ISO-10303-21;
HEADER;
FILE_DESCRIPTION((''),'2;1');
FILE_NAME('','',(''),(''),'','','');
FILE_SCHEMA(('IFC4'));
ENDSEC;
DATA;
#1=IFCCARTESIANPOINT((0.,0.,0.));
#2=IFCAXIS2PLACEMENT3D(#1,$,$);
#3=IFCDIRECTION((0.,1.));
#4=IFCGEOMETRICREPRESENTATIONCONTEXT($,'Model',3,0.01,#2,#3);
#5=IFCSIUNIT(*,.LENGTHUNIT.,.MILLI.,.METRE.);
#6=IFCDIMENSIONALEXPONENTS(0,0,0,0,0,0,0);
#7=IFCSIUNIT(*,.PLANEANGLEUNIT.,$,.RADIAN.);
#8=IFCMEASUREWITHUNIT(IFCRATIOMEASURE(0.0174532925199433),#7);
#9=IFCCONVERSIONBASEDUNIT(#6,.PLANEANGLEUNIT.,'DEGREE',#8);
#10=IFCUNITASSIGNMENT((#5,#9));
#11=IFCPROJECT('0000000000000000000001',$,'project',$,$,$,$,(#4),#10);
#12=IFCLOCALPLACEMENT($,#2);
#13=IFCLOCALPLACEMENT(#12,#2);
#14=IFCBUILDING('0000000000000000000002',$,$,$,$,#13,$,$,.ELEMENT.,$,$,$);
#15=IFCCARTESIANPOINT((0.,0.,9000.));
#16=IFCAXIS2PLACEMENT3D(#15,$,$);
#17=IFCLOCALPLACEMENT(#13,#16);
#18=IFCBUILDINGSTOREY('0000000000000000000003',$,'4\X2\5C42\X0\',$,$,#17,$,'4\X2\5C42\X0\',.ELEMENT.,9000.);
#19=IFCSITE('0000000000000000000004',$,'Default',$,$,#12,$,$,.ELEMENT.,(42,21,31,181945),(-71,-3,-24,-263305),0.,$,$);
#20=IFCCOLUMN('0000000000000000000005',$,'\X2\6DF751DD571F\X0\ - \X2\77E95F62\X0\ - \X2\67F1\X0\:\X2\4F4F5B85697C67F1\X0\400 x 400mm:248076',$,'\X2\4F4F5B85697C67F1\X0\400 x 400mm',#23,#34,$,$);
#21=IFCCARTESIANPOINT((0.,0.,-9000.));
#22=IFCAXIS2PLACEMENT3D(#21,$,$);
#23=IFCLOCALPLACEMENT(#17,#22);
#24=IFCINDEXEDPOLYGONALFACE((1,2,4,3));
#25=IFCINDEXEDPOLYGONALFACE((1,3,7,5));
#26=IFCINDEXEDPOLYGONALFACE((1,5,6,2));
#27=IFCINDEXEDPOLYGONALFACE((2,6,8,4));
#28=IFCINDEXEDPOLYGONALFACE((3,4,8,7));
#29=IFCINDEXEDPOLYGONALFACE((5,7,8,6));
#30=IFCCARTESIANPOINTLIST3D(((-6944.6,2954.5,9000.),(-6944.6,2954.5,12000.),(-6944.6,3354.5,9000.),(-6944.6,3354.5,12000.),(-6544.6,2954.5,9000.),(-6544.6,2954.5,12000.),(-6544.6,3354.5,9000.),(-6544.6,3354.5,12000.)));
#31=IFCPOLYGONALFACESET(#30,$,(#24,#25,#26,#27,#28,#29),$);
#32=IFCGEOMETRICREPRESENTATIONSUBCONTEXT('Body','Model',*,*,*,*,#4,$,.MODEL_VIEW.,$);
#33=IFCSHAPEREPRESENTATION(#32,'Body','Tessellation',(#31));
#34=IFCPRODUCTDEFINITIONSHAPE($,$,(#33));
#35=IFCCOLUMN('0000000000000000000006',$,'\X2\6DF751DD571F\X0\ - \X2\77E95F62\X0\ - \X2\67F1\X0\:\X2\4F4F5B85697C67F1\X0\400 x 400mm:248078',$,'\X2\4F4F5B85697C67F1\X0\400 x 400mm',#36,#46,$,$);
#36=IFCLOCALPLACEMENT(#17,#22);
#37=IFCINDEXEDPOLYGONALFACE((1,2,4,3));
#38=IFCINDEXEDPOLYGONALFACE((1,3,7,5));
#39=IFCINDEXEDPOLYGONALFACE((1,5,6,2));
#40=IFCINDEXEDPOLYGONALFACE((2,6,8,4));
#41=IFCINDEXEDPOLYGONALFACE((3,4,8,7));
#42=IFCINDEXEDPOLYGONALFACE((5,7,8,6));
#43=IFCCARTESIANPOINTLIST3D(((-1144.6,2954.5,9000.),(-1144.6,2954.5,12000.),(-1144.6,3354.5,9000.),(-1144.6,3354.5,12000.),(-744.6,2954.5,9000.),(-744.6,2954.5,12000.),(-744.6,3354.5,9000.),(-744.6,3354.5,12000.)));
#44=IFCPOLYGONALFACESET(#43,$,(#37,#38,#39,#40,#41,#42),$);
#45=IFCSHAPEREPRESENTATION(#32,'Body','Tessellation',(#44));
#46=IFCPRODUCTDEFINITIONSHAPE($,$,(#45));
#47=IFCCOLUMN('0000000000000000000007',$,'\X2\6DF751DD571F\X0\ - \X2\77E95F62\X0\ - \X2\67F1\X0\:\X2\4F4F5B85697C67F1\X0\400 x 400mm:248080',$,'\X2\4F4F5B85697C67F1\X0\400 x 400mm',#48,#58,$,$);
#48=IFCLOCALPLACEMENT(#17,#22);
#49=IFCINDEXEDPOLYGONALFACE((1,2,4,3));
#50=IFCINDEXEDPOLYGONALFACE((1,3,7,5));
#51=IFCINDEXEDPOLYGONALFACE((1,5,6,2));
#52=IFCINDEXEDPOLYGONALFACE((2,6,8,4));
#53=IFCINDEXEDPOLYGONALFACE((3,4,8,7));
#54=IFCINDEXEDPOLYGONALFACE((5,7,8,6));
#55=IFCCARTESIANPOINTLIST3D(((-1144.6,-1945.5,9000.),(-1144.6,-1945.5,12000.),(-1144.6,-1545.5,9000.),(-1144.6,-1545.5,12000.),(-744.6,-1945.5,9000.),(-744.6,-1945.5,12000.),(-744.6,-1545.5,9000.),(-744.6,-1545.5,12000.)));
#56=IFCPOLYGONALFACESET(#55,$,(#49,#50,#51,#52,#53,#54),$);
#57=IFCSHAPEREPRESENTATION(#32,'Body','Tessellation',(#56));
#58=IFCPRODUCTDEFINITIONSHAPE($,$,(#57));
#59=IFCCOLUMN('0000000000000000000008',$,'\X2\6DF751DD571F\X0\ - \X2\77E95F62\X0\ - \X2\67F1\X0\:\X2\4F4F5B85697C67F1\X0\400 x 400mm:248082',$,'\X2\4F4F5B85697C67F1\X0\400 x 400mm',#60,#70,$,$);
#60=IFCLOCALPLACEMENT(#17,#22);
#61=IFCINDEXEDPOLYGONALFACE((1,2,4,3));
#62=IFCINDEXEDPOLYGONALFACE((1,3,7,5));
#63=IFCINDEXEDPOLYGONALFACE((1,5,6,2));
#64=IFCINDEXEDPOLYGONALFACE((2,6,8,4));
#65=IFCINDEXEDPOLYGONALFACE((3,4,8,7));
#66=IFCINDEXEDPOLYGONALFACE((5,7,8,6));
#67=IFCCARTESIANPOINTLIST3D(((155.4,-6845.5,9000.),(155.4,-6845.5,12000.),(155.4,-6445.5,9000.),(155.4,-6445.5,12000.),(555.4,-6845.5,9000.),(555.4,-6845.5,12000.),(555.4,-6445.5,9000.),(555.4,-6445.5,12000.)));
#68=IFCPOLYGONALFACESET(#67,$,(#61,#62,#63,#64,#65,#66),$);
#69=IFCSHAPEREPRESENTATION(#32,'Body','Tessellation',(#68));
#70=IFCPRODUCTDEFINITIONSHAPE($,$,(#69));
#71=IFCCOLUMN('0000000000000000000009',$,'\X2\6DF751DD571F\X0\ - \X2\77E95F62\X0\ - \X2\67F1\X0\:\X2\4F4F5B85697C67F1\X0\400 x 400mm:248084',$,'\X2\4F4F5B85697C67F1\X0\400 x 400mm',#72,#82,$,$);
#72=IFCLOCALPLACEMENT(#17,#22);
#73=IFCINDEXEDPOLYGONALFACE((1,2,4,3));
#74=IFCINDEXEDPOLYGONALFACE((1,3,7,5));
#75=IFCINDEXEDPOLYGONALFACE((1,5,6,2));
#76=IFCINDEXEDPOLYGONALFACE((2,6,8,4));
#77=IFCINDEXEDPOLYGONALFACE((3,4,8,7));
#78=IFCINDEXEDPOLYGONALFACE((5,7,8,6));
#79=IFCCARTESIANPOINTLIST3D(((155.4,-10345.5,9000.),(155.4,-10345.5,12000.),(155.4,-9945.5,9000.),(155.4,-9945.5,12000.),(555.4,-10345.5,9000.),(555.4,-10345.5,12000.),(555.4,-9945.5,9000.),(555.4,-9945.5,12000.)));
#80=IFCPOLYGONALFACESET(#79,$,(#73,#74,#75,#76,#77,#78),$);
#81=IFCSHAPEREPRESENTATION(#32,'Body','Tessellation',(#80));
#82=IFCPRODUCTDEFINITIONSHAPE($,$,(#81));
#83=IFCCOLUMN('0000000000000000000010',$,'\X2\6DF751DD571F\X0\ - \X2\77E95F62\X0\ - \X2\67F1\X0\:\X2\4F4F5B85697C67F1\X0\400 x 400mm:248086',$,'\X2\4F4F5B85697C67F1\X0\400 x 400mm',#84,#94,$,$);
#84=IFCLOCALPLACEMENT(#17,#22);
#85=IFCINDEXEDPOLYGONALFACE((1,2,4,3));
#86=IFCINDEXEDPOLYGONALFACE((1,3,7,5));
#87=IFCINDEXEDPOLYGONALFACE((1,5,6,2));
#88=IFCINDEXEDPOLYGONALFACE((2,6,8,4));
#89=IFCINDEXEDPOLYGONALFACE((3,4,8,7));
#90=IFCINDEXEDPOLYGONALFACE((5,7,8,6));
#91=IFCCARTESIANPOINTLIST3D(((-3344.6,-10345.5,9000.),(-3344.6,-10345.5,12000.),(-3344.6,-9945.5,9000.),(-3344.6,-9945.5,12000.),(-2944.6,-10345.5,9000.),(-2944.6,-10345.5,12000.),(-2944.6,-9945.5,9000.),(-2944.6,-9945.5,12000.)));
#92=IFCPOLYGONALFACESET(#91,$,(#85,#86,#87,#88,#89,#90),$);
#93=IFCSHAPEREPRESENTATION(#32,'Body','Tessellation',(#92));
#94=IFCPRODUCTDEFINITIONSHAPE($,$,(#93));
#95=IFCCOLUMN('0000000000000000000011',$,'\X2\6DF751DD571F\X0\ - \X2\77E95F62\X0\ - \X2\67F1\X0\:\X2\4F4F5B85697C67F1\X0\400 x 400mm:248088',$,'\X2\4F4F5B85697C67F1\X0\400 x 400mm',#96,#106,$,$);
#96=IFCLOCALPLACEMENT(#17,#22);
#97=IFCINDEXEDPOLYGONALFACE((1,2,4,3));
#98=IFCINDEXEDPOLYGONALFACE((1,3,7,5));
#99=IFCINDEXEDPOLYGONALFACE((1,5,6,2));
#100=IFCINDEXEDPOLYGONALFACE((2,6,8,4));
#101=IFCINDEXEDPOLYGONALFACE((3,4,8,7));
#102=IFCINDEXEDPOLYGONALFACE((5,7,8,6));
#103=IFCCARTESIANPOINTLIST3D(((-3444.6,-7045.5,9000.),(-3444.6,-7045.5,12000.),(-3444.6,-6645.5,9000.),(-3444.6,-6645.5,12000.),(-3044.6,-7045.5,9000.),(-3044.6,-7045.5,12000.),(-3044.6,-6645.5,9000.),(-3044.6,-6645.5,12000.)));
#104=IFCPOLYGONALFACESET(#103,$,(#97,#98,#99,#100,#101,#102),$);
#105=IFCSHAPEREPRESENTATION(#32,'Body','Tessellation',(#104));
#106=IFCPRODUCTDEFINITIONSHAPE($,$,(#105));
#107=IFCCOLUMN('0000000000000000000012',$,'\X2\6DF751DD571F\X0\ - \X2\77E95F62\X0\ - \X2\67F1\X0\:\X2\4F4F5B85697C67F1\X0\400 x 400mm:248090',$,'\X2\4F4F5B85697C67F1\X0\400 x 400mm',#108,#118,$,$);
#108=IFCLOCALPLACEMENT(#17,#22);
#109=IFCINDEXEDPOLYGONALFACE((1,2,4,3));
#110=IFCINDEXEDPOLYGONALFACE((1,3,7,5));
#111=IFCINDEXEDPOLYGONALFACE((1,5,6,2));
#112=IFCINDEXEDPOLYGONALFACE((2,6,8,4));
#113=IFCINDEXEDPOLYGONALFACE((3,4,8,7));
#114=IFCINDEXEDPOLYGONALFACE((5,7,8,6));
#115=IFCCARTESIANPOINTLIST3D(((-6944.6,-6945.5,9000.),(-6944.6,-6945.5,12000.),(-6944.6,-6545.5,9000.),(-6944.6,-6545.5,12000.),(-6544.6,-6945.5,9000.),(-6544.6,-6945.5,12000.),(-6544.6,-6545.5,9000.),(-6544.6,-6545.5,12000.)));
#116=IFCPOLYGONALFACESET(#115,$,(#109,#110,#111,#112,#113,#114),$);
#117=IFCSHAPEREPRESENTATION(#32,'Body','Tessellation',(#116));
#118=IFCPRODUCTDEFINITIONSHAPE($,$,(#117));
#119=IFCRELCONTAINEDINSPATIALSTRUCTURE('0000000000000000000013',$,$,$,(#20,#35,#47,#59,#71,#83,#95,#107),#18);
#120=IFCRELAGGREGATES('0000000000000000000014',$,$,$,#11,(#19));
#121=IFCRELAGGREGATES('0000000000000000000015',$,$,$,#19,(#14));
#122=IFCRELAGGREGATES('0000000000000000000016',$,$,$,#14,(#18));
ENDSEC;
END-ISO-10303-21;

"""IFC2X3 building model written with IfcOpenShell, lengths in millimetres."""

from ifc_helpers import new_model, entity, si_unit, converted_unit, direction, frame, frame_2d, origin, origin_2d_with_axis, place, context, subcontext, project, spatial, rectangle, extrude, source, transform, mapped, element, save


model = new_model("IFC2X3")

# Units and contexts
model_context = context("Model", 3, precision=0.01, world=origin(), true_north=direction((0.0, 1.0)))
body_context = subcontext(model_context, "Body", "Model", "MODEL_VIEW")
ifc_project = project(units=[si_unit("LENGTHUNIT", "METRE", prefix="MILLI"), converted_unit("PLANEANGLEUNIT", "DEGREE", entity("IfcRatioMeasure", 0.0174532925199433), si_unit("PLANEANGLEUNIT", "RADIAN"), dimensions=[0, 0, 0, 0, 0, 0, 0])], contexts=[model_context])

# Site, building, storey
site_placement = place(None, origin())
site = spatial("IfcSite", under=ifc_project, at=site_placement, Name="Default", CompositionType="ELEMENT", RefLatitude=(42, 21, 31, 181945), RefLongitude=(-71, -3, -24, -263305), RefElevation=0.0)
building_placement = place(site_placement, origin())
building = spatial("IfcBuilding", under=site, at=building_placement, CompositionType="ELEMENT")
storey_placement = place(building_placement, frame((0.0, 0.0, 9000.0)))
storey = spatial("IfcBuildingStorey", under=building, at=storey_placement, Name="4层", LongName="4层", CompositionType="ELEMENT", Elevation=9000.0)

# Columns
shared_shape_1 = source(origin(), body_context, "Body", "SweptSolid", [
    extrude(rectangle(XDim=400.0, YDim=400.0, at=origin_2d_with_axis()), frame((-6744.6, 3154.5, 9000.0), z_axis=(0.0, 0.0, 1.0), x_axis=(0.0, -1.0, 0.0)), (0.0, 0.0, 1.0), 3000.0),
])
column_1_placement = place(storey_placement, frame((0.0, 0.0, -9000.0)))
element("IfcColumn", 1, at=column_1_placement, inside=storey, Name="混凝土 - 矩形 - 柱:住宅楼柱400 x 400mm:248076", ObjectType="住宅楼柱400 x 400mm", context=body_context, shape_type="MappedRepresentation", body=[
    mapped(shared_shape_1, transform((0.0, 0.0, 0.0), scale=1.0)),
])
shared_shape_2 = source(origin(), body_context, "Body", "SweptSolid", [
    extrude(rectangle(XDim=400.0, YDim=400.0, at=origin_2d_with_axis()), frame((-944.6, 3154.5, 9000.0), z_axis=(0.0, 0.0, 1.0), x_axis=(0.0, -1.0, 0.0)), (0.0, 0.0, 1.0), 3000.0),
])
column_2_placement = place(storey_placement, frame((0.0, 0.0, -9000.0)))
element("IfcColumn", 2, at=column_2_placement, inside=storey, Name="混凝土 - 矩形 - 柱:住宅楼柱400 x 400mm:248078", ObjectType="住宅楼柱400 x 400mm", context=body_context, shape_type="MappedRepresentation", body=[
    mapped(shared_shape_2, transform((0.0, 0.0, 0.0), scale=1.0)),
])
shared_shape_3 = source(origin(), body_context, "Body", "SweptSolid", [
    extrude(rectangle(XDim=400.0, YDim=400.0, at=origin_2d_with_axis()), frame((-944.6, -1745.5, 9000.0), z_axis=(0.0, 0.0, 1.0), x_axis=(0.0, -1.0, 0.0)), (0.0, 0.0, 1.0), 3000.0),
])
column_3_placement = place(storey_placement, frame((0.0, 0.0, -9000.0)))
element("IfcColumn", 3, at=column_3_placement, inside=storey, Name="混凝土 - 矩形 - 柱:住宅楼柱400 x 400mm:248080", ObjectType="住宅楼柱400 x 400mm", context=body_context, shape_type="MappedRepresentation", body=[
    mapped(shared_shape_3, transform((0.0, 0.0, 0.0), scale=1.0)),
])
shared_shape_4 = source(origin(), body_context, "Body", "SweptSolid", [
    extrude(rectangle(XDim=400.0, YDim=400.0, at=frame_2d((0.0, 0.0), x_axis=(1.0, 0.0))), frame((355.4, -6645.5, 9000.0), z_axis=(0.0, 0.0, 1.0), x_axis=(0.0, -1.0, 0.0)), (0.0, 0.0, 1.0), 3000.0),
])
column_4_placement = place(storey_placement, frame((0.0, 0.0, -9000.0)))
element("IfcColumn", 4, at=column_4_placement, inside=storey, Name="混凝土 - 矩形 - 柱:住宅楼柱400 x 400mm:248082", ObjectType="住宅楼柱400 x 400mm", context=body_context, shape_type="MappedRepresentation", body=[
    mapped(shared_shape_4, transform((0.0, 0.0, 0.0), scale=1.0)),
])
shared_shape_5 = source(origin(), body_context, "Body", "SweptSolid", [
    extrude(rectangle(XDim=400.0, YDim=400.0, at=frame_2d((0.0, 0.0), x_axis=(1.0, 0.0))), frame((355.4, -10145.5, 9000.0), z_axis=(0.0, 0.0, 1.0), x_axis=(0.0, -1.0, 0.0)), (0.0, 0.0, 1.0), 3000.0),
])
column_5_placement = place(storey_placement, frame((0.0, 0.0, -9000.0)))
element("IfcColumn", 5, at=column_5_placement, inside=storey, Name="混凝土 - 矩形 - 柱:住宅楼柱400 x 400mm:248084", ObjectType="住宅楼柱400 x 400mm", context=body_context, shape_type="MappedRepresentation", body=[
    mapped(shared_shape_5, transform((0.0, 0.0, 0.0), scale=1.0)),
])
shared_shape_6 = source(origin(), body_context, "Body", "SweptSolid", [
    extrude(rectangle(XDim=400.0, YDim=400.0, at=origin_2d_with_axis()), frame((-3144.6, -10145.5, 9000.0), z_axis=(0.0, 0.0, 1.0), x_axis=(0.0, -1.0, 0.0)), (0.0, 0.0, 1.0), 3000.0),
])
column_6_placement = place(storey_placement, frame((0.0, 0.0, -9000.0)))
element("IfcColumn", 6, at=column_6_placement, inside=storey, Name="混凝土 - 矩形 - 柱:住宅楼柱400 x 400mm:248086", ObjectType="住宅楼柱400 x 400mm", context=body_context, shape_type="MappedRepresentation", body=[
    mapped(shared_shape_6, transform((0.0, 0.0, 0.0), scale=1.0)),
])
shared_shape_7 = source(origin(), body_context, "Body", "SweptSolid", [
    extrude(rectangle(XDim=400.0, YDim=400.0, at=origin_2d_with_axis()), frame((-3244.6, -6845.5, 9000.0), z_axis=(0.0, 0.0, 1.0), x_axis=(0.0, -1.0, 0.0)), (0.0, 0.0, 1.0), 3000.0),
])
column_7_placement = place(storey_placement, frame((0.0, 0.0, -9000.0)))
element("IfcColumn", 7, at=column_7_placement, inside=storey, Name="混凝土 - 矩形 - 柱:住宅楼柱400 x 400mm:248088", ObjectType="住宅楼柱400 x 400mm", context=body_context, shape_type="MappedRepresentation", body=[
    mapped(shared_shape_7, transform((0.0, 0.0, 0.0), scale=1.0)),
])
shared_shape_8 = source(origin(), body_context, "Body", "SweptSolid", [
    extrude(rectangle(XDim=400.0, YDim=400.0, at=origin_2d_with_axis()), frame((-6744.6, -6745.5, 9000.0), z_axis=(0.0, 0.0, 1.0), x_axis=(0.0, -1.0, 0.0)), (0.0, 0.0, 1.0), 3000.0),
])
column_8_placement = place(storey_placement, frame((0.0, 0.0, -9000.0)))
element("IfcColumn", 8, at=column_8_placement, inside=storey, Name="混凝土 - 矩形 - 柱:住宅楼柱400 x 400mm:248090", ObjectType="住宅楼柱400 x 400mm", context=body_context, shape_type="MappedRepresentation", body=[
    mapped(shared_shape_8, transform((0.0, 0.0, 0.0), scale=1.0)),
])

save(model, "model.ifc")
